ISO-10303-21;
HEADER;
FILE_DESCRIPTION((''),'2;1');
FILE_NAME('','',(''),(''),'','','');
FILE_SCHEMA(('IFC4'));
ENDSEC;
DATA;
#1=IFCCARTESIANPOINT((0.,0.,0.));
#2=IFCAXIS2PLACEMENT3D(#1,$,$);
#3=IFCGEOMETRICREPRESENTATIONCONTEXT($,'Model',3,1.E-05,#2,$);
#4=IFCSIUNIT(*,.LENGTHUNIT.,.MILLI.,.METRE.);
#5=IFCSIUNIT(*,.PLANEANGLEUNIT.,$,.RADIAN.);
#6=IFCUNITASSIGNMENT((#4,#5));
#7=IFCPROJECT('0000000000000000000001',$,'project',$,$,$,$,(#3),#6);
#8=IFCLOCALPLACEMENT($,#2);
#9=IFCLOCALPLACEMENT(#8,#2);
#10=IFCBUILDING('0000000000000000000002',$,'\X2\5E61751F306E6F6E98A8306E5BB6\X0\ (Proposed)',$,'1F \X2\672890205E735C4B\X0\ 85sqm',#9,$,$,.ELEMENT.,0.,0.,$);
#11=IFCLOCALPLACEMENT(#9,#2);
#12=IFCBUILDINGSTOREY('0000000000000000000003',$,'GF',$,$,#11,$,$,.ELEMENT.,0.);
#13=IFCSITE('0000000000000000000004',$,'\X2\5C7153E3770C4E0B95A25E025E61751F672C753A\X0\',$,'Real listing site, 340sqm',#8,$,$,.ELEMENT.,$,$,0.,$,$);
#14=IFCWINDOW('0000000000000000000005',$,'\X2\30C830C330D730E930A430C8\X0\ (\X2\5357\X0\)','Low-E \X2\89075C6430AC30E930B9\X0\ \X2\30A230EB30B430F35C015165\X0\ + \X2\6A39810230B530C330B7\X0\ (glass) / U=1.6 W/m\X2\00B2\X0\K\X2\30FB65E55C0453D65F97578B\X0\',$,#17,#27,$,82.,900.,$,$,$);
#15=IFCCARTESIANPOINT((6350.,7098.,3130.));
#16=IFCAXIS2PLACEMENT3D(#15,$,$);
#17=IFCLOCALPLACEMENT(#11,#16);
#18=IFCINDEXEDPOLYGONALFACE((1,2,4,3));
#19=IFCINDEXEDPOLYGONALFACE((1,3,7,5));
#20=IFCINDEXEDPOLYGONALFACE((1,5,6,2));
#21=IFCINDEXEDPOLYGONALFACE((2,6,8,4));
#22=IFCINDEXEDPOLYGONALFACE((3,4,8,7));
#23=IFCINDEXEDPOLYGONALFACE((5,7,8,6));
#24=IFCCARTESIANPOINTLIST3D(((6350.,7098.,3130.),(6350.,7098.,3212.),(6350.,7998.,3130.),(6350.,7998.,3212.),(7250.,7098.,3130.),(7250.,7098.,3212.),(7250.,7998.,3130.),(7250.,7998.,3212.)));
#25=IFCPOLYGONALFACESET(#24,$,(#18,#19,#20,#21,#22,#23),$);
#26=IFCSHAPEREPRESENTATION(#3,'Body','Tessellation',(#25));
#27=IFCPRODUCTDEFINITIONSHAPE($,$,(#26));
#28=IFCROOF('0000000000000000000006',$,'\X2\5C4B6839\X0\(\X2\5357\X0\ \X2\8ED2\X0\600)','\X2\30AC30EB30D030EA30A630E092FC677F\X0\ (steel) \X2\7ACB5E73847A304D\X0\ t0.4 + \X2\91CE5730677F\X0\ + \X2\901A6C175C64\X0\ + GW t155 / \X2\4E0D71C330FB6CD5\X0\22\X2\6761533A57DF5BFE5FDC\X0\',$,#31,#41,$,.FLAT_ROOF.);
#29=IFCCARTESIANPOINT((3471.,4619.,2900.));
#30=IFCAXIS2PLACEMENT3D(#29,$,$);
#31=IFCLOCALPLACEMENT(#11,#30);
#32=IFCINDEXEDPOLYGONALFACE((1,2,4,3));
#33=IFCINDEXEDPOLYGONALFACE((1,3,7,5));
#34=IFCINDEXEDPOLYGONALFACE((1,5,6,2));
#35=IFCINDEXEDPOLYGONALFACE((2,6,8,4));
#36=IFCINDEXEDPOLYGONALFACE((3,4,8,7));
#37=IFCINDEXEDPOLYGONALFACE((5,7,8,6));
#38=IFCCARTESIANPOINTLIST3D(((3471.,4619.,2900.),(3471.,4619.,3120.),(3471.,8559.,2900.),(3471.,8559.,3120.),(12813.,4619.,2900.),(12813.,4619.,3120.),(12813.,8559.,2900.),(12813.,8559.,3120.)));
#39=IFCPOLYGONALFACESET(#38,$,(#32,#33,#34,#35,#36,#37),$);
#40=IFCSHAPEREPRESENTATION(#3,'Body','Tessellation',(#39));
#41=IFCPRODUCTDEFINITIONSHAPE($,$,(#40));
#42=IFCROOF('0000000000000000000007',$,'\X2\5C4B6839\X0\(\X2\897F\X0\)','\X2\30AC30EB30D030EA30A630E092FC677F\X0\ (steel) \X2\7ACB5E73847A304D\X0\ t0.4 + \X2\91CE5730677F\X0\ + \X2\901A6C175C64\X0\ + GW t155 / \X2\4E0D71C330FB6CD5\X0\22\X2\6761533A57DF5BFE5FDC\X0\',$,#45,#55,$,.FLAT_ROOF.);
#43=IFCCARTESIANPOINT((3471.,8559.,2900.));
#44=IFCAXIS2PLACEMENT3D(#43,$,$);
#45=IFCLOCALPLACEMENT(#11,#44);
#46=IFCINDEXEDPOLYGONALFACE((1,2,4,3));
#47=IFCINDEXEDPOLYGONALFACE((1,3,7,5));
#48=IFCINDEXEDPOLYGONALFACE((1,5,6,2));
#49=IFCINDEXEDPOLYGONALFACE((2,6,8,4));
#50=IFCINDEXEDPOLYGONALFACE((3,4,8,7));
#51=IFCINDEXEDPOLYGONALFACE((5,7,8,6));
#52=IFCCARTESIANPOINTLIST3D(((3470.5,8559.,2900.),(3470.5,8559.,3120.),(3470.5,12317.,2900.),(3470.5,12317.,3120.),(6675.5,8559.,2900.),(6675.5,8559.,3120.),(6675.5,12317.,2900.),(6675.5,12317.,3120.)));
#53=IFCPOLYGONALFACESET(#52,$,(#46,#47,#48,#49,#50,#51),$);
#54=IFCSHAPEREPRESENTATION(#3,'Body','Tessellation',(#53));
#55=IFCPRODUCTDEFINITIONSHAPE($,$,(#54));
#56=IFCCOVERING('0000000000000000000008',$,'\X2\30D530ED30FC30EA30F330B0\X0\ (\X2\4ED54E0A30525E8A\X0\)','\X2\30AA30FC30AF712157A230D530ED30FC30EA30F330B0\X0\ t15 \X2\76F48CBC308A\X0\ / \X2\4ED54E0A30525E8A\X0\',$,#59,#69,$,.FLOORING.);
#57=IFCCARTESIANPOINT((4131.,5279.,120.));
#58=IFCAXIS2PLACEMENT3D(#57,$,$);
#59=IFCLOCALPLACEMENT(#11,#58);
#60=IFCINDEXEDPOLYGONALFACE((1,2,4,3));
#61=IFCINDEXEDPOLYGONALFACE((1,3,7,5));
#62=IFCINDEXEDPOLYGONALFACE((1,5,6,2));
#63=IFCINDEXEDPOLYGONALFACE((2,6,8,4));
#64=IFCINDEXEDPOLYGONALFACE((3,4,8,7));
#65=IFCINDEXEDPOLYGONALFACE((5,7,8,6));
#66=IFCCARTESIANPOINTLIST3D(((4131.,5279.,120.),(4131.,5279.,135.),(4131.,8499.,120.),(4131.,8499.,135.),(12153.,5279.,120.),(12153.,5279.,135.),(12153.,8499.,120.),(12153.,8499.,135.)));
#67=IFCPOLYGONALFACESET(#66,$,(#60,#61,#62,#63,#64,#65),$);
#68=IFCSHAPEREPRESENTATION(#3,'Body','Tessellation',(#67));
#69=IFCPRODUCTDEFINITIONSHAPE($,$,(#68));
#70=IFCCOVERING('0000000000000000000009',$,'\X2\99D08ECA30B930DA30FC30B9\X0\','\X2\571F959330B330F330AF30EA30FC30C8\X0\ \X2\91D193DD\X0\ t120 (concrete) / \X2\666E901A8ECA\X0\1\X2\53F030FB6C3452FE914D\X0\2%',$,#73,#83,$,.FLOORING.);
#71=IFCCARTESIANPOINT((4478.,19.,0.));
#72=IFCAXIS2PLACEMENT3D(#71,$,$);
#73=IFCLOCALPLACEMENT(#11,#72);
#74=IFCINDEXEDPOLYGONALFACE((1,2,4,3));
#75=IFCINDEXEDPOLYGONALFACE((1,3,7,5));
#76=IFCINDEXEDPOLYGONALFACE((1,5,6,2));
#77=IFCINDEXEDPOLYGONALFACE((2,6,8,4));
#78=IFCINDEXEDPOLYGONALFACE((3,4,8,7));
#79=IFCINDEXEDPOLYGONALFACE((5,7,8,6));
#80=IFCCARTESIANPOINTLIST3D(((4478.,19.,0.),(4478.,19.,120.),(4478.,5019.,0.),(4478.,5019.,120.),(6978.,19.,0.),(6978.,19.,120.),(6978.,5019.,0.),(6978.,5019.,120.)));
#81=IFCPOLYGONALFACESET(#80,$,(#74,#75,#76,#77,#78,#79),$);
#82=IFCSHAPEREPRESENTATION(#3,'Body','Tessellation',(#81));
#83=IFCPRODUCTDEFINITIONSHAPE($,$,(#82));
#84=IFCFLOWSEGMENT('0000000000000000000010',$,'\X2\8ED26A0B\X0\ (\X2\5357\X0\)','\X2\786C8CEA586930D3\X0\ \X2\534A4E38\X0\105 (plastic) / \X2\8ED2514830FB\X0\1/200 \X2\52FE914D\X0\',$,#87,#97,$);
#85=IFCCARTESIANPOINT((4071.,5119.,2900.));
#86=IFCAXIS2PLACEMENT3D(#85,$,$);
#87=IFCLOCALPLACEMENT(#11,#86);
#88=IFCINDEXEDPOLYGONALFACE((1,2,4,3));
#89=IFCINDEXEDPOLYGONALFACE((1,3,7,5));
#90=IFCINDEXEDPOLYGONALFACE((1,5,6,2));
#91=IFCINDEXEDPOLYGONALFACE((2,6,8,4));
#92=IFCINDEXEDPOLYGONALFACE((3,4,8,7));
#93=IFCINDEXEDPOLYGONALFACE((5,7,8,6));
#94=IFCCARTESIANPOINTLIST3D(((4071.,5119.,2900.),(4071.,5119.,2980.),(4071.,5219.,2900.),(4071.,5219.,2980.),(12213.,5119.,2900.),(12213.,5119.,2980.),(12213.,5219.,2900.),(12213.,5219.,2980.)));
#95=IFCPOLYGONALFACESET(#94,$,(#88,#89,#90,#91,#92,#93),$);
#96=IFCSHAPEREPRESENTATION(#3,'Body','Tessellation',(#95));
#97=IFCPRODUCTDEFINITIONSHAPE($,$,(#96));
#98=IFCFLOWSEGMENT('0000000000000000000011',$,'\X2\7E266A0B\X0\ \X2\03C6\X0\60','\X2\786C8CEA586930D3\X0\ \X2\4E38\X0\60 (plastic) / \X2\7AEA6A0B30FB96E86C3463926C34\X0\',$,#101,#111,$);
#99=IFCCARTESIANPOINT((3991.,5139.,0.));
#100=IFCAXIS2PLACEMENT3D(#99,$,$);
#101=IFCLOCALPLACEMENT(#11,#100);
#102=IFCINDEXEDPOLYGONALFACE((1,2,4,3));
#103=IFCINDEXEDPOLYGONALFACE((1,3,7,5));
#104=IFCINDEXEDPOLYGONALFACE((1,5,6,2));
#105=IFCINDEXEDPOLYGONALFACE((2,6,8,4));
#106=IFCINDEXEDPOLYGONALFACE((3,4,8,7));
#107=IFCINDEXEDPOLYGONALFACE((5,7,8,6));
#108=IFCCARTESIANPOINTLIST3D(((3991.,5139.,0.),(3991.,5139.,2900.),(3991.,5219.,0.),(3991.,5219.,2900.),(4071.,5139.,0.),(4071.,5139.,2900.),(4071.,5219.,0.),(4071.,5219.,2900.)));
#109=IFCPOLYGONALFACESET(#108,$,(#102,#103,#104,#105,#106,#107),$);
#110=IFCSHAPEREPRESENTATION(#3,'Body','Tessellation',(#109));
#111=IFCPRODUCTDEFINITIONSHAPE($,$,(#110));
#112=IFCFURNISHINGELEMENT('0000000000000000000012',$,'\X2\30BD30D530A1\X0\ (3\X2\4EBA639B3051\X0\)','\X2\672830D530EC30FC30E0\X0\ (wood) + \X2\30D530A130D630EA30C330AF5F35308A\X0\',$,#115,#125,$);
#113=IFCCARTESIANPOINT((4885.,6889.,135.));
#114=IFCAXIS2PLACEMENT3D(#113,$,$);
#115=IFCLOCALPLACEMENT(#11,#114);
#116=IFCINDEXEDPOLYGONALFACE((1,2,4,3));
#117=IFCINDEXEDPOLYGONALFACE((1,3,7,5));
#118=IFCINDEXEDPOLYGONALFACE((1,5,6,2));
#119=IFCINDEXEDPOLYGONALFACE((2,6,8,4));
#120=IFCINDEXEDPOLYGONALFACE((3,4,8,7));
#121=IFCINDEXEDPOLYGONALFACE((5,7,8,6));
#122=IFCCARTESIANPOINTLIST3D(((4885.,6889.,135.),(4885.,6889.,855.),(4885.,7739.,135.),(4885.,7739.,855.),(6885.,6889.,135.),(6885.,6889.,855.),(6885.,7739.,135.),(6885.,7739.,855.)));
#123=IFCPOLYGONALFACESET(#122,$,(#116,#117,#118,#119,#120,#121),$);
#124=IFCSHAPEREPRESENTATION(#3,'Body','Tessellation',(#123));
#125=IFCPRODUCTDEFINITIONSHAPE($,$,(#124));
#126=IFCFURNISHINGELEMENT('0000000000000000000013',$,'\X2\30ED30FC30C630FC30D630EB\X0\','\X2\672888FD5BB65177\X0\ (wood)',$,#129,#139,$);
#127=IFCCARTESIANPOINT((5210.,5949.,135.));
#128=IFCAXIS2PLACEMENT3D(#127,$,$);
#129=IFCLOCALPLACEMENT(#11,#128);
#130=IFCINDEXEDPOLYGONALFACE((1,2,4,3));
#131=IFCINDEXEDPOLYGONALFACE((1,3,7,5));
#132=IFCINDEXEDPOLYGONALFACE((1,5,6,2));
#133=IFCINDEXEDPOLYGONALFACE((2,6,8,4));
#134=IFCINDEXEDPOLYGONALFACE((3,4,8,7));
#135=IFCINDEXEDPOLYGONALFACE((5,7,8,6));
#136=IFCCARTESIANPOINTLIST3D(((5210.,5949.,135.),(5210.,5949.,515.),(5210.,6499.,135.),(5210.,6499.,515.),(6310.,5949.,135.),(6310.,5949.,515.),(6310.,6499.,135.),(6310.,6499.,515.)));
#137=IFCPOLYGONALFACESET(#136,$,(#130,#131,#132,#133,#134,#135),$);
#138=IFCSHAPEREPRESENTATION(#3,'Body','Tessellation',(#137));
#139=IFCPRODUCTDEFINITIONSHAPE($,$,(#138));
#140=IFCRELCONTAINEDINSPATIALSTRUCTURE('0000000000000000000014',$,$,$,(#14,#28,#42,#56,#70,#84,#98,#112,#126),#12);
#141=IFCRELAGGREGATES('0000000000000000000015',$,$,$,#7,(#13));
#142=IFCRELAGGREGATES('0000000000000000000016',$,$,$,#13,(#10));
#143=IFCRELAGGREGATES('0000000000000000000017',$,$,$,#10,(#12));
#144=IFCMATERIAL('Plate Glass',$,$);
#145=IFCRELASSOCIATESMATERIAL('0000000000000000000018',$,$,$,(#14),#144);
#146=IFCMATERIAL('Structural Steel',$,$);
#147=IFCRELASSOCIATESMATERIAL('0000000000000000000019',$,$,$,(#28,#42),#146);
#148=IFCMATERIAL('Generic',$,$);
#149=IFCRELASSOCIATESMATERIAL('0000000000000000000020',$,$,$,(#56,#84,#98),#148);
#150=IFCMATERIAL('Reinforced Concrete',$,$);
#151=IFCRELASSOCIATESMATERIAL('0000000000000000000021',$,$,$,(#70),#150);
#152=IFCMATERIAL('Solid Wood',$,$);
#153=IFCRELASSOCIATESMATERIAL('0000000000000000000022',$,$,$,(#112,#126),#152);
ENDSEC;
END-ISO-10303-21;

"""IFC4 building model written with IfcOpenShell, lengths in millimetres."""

from ifc_helpers import new_model, si_unit, frame, frame_2d, origin, place, context, project, spatial, rectangle, extrude, material, element, save


model = new_model("IFC4")

# Units and contexts
model_context = context("Model", 3, precision=1e-05, world=origin())
ifc_project = project(units=[si_unit("LENGTHUNIT", "METRE", prefix="MILLI"), si_unit("PLANEANGLEUNIT", "RADIAN")], contexts=[model_context])

# Site, building, storey
site_placement = place(None, origin())
site = spatial("IfcSite", under=ifc_project, at=site_placement, Name="山口県下関市幡生本町", ObjectType="Real listing site, 340sqm", CompositionType="ELEMENT", RefElevation=0.0)
building_placement = place(site_placement, origin())
building = spatial("IfcBuilding", under=site, at=building_placement, Name="幡生の潮風の家 (Proposed)", ObjectType="1F 木造平屋 85sqm", CompositionType="ELEMENT", ElevationOfRefHeight=0.0, ElevationOfTerrain=0.0)
storey_placement = place(building_placement, origin())
storey = spatial("IfcBuildingStorey", under=building, at=storey_placement, Name="GF", CompositionType="ELEMENT", Elevation=0.0)

# Shared definitions
ifc_material_1 = material(Name="Solid Wood")

# Shared definitions
ifc_material_2 = material(Name="Reinforced Concrete")

# Shared definitions
ifc_material_3 = material(Name="Plate Glass")

# Window
window_1_placement = place(storey_placement, frame((6350.0, 7098.0, 3130.0)))
element("IfcWindow", 1, at=window_1_placement, inside=storey, material=ifc_material_3, Name="トップライト (南)", Description="Low-E 複層ガラス アルゴン封入 + 樹脂サッシ (glass) / U=1.6 W/m²K・日射取得型", OverallHeight=82.0, OverallWidth=900.0, context=model_context, shape_type="SweptSolid", body=[
    extrude(rectangle(XDim=900.0, YDim=900.0, at=frame_2d((450.0, 450.0))), frame((6350.0, 7098.0, 3130.0)), (0.0, 0.0, 1.0), 82.0),
])

# Roofs
ifc_material_4 = material(Name="Structural Steel")
roof_1_placement = place(storey_placement, frame((3471.0, 4619.0, 2900.0)))
element("IfcRoof", 2, at=roof_1_placement, inside=storey, material=ifc_material_4, Name="屋根(南 軒600)", Description="ガルバリウム鋼板 (steel) 立平葺き t0.4 + 野地板 + 通気層 + GW t155 / 不燃・法22条区域対応", PredefinedType="FLAT_ROOF", context=model_context, shape_type="SweptSolid", body=[
    extrude(rectangle(XDim=9342.0, YDim=3940.0, at=frame_2d((4671.0, 1970.0))), frame((3471.0, 4619.0, 2900.0)), (0.0, 0.0, 1.0), 220.0),
])
roof_2_placement = place(storey_placement, frame((3471.0, 8559.0, 2900.0)))
element("IfcRoof", 3, at=roof_2_placement, inside=storey, material=ifc_material_4, Name="屋根(西)", Description="ガルバリウム鋼板 (steel) 立平葺き t0.4 + 野地板 + 通気層 + GW t155 / 不燃・法22条区域対応", PredefinedType="FLAT_ROOF", context=model_context, shape_type="SweptSolid", body=[
    extrude(rectangle(XDim=3205.0, YDim=3758.0, at=frame_2d((1602.0, 1879.0))), frame((3471.0, 8559.0, 2900.0)), (0.0, 0.0, 1.0), 220.0),
])

# Coverings
ifc_material_5 = material(Name="Generic")
covering_1_placement = place(storey_placement, frame((4131.0, 5279.0, 120.0)))
element("IfcCovering", 4, at=covering_1_placement, inside=storey, material=ifc_material_5, Name="フローリング (仕上げ床)", Description="オーク無垢フローリング t15 直貼り / 仕上げ床", PredefinedType="FLOORING", context=model_context, shape_type="SweptSolid", body=[
    extrude(rectangle(XDim=8022.0, YDim=3220.0, at=frame_2d((4011.0, 1610.0))), frame((4131.0, 5279.0, 120.0)), (0.0, 0.0, 1.0), 15.0),
])
covering_2_placement = place(storey_placement, frame((4478.0, 19.0, 0.0)))
element("IfcCovering", 5, at=covering_2_placement, inside=storey, material=ifc_material_2, Name="駐車スペース", Description="土間コンクリート 金鏝 t120 (concrete) / 普通車1台・水勾配2%", PredefinedType="FLOORING", context=model_context, shape_type="SweptSolid", body=[
    extrude(rectangle(XDim=2500.0, YDim=5000.0, at=frame_2d((1250.0, 2500.0))), frame((4478.0, 19.0, 0.0)), (0.0, 0.0, 1.0), 120.0),
])

# Flow segments
flow_segment_1_placement = place(storey_placement, frame((4071.0, 5119.0, 2900.0)))
element("IfcFlowSegment", 6, at=flow_segment_1_placement, inside=storey, material=ifc_material_5, Name="軒樋 (南)", Description="硬質塩ビ 半丸105 (plastic) / 軒先・1/200 勾配", context=model_context, shape_type="SweptSolid", body=[
    extrude(rectangle(XDim=8142.0, YDim=100.0, at=frame_2d((4071.0, 50.0))), frame((4071.0, 5119.0, 2900.0)), (0.0, 0.0, 1.0), 80.0),
])
flow_segment_2_placement = place(storey_placement, frame((3991.0, 5139.0, 0.0)))
element("IfcFlowSegment", 7, at=flow_segment_2_placement, inside=storey, material=ifc_material_5, Name="縦樋 φ60", Description="硬質塩ビ 丸60 (plastic) / 竪樋・雨水排水", context=model_context, shape_type="SweptSolid", body=[
    extrude(rectangle(XDim=80.0, YDim=80.0, at=frame_2d((40.0, 40.0))), frame((3991.0, 5139.0, 0.0)), (0.0, 0.0, 1.0), 2900.0),
])

# Furnishing elements
furnishing_1_placement = place(storey_placement, frame((4885.0, 6889.0, 135.0)))
element("IfcFurnishingElement", 8, at=furnishing_1_placement, inside=storey, material=ifc_material_1, Name="ソファ (3人掛け)", Description="木フレーム (wood) + ファブリック張り", context=model_context, shape_type="SweptSolid", body=[
    extrude(rectangle(XDim=2000.0, YDim=850.0, at=frame_2d((1000.0, 425.0))), frame((4885.0, 6889.0, 135.0)), (0.0, 0.0, 1.0), 720.0),
])
furnishing_2_placement = place(storey_placement, frame((5210.0, 5949.0, 135.0)))
element("IfcFurnishingElement", 9, at=furnishing_2_placement, inside=storey, material=ifc_material_1, Name="ローテーブル", Description="木製家具 (wood)", context=model_context, shape_type="SweptSolid", body=[
    extrude(rectangle(XDim=1100.0, YDim=550.0, at=frame_2d((550.0, 275.0))), frame((5210.0, 5949.0, 135.0)), (0.0, 0.0, 1.0), 380.0),
])

save(model, "model.ifc")
